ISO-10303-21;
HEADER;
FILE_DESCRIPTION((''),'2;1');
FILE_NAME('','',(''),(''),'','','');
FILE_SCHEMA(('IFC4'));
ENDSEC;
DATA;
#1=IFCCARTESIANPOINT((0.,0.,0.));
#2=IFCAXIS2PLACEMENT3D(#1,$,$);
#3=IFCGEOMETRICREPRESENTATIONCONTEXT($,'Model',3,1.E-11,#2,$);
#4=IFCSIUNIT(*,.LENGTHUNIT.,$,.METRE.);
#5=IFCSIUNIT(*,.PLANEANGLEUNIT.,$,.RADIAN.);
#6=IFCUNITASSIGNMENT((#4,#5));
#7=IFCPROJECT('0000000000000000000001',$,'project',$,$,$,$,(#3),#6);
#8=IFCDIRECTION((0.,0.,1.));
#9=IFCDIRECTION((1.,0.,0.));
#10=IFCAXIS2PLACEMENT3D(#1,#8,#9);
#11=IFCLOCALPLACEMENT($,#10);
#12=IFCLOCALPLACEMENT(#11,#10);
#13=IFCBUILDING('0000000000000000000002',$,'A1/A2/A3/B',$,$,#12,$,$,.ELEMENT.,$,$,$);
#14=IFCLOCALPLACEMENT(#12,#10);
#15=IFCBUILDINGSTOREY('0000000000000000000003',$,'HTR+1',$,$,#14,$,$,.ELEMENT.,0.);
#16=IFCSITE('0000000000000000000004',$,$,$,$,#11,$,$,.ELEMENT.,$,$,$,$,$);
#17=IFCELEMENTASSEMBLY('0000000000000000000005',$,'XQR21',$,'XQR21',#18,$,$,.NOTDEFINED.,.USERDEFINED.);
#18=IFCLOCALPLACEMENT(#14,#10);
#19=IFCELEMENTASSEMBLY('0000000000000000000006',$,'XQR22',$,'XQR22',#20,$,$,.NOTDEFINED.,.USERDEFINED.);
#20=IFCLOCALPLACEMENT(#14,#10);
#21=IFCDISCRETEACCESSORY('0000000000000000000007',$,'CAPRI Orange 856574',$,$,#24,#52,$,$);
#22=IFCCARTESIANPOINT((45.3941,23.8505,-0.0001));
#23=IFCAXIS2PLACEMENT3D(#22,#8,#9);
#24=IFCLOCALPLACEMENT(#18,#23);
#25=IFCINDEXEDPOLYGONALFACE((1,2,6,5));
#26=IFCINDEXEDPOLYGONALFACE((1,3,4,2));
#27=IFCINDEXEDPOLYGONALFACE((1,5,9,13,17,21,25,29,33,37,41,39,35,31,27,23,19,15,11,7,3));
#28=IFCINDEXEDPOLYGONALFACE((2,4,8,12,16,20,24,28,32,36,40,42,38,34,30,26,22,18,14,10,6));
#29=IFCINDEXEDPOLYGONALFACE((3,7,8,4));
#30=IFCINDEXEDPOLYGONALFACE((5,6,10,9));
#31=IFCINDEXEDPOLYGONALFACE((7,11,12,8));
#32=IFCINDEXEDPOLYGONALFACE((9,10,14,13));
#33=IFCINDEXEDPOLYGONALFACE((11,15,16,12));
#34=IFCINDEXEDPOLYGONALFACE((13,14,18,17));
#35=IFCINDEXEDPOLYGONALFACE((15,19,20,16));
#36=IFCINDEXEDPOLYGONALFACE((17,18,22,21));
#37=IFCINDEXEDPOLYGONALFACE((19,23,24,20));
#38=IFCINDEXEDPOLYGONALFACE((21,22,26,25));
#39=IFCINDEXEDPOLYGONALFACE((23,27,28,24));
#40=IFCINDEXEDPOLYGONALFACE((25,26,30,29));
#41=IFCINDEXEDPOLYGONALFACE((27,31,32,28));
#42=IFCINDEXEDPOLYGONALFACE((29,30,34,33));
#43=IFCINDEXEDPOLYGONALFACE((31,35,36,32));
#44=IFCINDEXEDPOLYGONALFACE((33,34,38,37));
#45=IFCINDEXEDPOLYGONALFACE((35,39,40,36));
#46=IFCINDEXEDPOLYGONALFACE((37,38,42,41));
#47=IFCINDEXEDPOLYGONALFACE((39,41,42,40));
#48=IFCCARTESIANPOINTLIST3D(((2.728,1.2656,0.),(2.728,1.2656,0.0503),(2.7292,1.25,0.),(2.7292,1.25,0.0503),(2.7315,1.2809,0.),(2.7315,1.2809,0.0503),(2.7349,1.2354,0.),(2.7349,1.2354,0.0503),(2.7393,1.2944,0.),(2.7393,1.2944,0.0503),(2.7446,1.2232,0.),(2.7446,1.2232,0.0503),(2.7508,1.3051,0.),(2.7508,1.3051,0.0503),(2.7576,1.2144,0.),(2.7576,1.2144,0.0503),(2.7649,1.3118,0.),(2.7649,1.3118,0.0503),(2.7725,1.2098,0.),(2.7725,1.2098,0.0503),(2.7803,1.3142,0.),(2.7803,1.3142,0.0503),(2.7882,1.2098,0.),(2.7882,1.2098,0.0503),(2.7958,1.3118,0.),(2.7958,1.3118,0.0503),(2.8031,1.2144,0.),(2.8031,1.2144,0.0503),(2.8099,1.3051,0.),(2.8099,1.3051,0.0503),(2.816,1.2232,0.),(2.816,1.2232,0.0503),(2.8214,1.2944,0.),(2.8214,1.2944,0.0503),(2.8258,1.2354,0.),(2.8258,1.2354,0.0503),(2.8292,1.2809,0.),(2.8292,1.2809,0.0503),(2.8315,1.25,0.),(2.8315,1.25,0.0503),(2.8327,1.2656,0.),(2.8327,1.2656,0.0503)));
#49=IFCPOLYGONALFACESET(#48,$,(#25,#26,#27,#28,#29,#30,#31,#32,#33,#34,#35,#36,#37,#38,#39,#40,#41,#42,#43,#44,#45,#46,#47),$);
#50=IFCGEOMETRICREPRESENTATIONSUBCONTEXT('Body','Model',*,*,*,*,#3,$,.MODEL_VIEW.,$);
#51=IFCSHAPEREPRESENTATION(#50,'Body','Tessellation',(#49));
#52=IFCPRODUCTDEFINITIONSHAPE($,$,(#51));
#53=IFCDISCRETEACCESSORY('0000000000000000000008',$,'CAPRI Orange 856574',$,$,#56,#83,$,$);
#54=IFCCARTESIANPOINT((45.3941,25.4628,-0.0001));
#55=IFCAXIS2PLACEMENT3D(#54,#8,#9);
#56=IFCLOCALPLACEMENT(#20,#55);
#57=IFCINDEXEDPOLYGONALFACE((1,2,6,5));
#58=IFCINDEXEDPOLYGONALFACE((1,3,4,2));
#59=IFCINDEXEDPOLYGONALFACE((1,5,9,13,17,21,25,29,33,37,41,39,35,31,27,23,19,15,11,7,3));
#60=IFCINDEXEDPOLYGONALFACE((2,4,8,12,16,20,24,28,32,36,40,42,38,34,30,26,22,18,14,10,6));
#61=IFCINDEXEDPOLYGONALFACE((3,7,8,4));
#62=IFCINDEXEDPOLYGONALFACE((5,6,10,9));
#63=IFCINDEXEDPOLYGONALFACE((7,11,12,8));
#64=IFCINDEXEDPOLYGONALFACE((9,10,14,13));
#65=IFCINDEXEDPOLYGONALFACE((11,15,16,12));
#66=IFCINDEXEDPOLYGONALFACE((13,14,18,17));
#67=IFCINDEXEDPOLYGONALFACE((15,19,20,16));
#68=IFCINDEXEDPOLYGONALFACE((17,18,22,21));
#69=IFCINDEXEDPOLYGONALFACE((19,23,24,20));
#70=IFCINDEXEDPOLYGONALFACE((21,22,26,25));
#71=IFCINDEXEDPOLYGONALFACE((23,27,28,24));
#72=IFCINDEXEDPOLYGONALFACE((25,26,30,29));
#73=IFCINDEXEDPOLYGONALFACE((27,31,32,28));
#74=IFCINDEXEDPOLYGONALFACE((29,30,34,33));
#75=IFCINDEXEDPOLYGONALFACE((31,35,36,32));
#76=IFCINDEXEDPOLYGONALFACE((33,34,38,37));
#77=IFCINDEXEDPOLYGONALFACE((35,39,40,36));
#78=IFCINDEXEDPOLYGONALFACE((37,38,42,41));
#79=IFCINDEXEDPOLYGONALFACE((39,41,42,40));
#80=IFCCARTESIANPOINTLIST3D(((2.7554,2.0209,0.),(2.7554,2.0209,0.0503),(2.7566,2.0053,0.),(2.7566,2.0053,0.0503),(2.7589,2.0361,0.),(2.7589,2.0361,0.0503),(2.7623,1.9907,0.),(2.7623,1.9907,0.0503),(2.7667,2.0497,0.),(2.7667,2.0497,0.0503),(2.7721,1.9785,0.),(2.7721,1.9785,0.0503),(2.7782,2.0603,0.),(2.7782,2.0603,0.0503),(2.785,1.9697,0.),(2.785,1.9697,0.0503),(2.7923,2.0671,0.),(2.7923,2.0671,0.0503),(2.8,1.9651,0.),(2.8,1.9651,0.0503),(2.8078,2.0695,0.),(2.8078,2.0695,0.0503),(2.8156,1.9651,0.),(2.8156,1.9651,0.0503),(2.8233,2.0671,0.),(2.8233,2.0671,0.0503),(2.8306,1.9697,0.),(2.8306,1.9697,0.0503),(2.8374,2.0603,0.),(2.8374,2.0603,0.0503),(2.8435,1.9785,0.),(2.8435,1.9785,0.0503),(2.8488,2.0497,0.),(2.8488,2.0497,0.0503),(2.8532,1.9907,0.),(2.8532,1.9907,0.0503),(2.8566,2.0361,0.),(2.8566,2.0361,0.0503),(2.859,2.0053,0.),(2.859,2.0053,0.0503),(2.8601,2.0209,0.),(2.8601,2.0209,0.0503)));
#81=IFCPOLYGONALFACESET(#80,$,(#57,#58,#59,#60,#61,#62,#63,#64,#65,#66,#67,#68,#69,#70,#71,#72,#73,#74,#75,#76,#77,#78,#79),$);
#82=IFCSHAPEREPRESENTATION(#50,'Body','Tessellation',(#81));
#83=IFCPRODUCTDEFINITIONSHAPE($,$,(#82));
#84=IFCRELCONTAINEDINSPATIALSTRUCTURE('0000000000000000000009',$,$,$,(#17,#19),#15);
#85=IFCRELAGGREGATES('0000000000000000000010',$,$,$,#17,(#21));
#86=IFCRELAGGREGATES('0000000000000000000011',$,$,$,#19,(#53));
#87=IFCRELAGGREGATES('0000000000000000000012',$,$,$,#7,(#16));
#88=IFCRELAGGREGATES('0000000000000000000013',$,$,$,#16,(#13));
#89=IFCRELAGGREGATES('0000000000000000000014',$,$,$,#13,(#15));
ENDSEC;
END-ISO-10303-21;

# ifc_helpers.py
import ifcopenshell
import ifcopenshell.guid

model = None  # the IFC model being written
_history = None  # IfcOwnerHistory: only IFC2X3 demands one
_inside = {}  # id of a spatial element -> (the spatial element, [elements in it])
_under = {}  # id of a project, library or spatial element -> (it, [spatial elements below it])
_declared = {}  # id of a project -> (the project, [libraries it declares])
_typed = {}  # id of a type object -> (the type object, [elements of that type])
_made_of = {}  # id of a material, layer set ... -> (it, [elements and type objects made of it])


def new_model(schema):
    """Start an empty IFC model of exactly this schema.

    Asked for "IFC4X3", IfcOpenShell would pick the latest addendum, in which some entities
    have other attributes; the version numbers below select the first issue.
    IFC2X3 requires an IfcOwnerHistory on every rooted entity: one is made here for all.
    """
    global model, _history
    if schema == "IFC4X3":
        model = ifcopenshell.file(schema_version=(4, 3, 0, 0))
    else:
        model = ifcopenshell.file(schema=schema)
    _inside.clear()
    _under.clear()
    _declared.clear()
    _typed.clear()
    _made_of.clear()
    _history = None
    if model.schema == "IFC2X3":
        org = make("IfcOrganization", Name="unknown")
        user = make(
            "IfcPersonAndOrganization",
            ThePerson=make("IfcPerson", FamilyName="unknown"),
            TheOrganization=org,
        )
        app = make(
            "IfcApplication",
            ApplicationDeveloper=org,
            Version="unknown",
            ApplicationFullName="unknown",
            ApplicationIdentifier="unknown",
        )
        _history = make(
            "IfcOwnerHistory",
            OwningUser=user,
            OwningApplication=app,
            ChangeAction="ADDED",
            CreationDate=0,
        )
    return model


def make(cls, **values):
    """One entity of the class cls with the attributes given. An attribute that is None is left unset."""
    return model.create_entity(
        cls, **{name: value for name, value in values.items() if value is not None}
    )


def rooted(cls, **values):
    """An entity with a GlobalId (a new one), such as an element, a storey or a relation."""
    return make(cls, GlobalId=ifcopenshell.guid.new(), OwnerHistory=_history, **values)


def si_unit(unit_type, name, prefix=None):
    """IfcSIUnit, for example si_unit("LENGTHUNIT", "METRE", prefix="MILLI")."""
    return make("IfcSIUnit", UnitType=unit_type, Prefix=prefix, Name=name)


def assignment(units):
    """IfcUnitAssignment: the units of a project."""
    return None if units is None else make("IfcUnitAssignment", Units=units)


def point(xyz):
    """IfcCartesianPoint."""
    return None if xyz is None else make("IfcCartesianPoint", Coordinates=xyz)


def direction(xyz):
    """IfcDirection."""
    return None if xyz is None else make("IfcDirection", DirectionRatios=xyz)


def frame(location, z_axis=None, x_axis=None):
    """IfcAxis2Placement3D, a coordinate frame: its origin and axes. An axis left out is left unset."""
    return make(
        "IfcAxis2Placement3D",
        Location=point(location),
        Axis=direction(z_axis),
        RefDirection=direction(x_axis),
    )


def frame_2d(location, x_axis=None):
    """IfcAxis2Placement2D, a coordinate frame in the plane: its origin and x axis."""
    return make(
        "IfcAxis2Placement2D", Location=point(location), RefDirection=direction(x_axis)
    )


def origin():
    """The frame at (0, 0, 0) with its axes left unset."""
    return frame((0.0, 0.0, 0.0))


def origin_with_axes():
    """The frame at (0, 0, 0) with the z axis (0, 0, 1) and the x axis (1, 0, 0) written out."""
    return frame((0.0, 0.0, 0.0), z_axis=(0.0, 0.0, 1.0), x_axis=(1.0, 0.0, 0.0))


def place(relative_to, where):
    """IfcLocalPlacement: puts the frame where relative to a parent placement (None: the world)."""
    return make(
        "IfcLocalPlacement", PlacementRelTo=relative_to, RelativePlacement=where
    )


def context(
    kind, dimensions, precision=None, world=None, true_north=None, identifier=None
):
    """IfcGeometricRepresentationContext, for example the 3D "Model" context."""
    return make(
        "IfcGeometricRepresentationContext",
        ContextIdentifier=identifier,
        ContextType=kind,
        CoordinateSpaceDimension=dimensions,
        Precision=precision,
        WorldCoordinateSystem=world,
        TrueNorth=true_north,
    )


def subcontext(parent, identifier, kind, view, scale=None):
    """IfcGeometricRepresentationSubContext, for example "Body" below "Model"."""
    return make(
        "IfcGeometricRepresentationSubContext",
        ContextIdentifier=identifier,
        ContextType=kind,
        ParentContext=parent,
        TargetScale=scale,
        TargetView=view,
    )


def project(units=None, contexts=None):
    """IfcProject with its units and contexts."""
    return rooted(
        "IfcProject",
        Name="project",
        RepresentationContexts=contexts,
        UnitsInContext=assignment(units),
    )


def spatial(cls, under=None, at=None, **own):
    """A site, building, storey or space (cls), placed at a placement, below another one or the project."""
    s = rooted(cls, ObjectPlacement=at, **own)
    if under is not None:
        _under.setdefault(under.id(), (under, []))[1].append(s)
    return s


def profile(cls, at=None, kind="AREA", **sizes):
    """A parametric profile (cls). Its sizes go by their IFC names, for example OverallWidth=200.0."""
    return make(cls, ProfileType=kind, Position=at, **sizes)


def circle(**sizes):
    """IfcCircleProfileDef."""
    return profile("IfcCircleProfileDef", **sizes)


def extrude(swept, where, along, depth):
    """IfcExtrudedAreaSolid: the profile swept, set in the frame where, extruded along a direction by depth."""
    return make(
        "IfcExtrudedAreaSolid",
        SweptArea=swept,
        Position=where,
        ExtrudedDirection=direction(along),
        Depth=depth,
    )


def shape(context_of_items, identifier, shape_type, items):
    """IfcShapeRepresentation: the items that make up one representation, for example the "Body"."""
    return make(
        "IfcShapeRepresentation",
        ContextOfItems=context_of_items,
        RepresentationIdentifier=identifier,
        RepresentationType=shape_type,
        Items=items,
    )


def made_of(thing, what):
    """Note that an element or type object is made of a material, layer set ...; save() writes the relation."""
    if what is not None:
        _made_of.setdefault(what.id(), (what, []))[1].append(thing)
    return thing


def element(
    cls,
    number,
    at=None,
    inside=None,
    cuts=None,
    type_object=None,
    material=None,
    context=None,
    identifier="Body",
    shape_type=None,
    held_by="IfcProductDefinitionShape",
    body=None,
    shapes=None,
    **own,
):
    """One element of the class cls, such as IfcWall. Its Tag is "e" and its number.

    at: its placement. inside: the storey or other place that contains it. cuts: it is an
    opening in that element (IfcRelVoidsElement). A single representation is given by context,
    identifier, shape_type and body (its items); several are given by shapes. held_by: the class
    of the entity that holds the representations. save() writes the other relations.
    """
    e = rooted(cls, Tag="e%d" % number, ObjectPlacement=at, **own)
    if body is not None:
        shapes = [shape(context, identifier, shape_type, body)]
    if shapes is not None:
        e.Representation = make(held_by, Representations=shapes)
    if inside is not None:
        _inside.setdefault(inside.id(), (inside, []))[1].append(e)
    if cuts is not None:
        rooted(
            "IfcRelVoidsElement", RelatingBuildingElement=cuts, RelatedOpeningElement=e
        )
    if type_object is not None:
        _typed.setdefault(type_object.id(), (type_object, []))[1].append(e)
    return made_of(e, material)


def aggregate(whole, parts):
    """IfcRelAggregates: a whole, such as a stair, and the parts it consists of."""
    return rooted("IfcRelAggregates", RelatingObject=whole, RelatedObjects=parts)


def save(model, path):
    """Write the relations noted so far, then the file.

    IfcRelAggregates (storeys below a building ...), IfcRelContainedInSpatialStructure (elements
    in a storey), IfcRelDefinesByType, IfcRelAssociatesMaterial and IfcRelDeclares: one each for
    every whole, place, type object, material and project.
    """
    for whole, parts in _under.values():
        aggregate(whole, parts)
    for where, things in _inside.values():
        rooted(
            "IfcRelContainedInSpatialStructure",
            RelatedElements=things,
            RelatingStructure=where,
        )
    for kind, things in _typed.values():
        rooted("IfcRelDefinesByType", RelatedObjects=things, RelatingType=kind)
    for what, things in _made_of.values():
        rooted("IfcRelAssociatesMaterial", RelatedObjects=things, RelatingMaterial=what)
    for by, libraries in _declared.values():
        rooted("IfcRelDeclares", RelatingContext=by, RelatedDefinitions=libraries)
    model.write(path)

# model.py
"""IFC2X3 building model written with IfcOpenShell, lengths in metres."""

from ifc_helpers import new_model, si_unit, frame, frame_2d, origin, origin_with_axes, place, context, subcontext, project, spatial, circle, extrude, element, aggregate, save


model = new_model("IFC2X3")

# Units and contexts
model_context = context("Model", 3, precision=1e-11, world=origin())
body_context = subcontext(model_context, "Body", "Model", "MODEL_VIEW")
ifc_project = project(units=[si_unit("LENGTHUNIT", "METRE"), si_unit("PLANEANGLEUNIT", "RADIAN")], contexts=[model_context])

# Site, building, storey
site_placement = place(None, origin_with_axes())
site = spatial("IfcSite", under=ifc_project, at=site_placement, CompositionType="ELEMENT")
building_placement = place(site_placement, origin_with_axes())
building = spatial("IfcBuilding", under=site, at=building_placement, Name="A1/A2/A3/B", CompositionType="ELEMENT")
storey_placement = place(building_placement, origin_with_axes())
storey = spatial("IfcBuildingStorey", under=building, at=storey_placement, Name="HTR+1", CompositionType="ELEMENT", Elevation=0.0)

# Element assembly
assembly_1_placement = place(storey_placement, origin_with_axes())
assembly_1 = element("IfcElementAssembly", 1, at=assembly_1_placement, inside=storey, Name="XQR21", ObjectType="XQR21", AssemblyPlace="NOTDEFINED", PredefinedType="USERDEFINED")

# Element assembly
assembly_2_placement = place(storey_placement, origin_with_axes())
assembly_2 = element("IfcElementAssembly", 2, at=assembly_2_placement, inside=storey, Name="XQR22", ObjectType="XQR22", AssemblyPlace="NOTDEFINED", PredefinedType="USERDEFINED")

# Discrete accessories
discrete_accessory_1_placement = place(assembly_1_placement, frame((45.3941, 23.8505, -0.0001), z_axis=(0.0, 0.0, 1.0), x_axis=(1.0, 0.0, 0.0)))
discrete_accessory_1 = element("IfcDiscreteAccessory", 3, at=discrete_accessory_1_placement, Name="CAPRI Orange 856574", context=body_context, shape_type="SweptSolid", body=[
    extrude(circle(Radius=0.0525, at=frame_2d((1.2617, -2.7803), x_axis=(1.0, 0.0))), frame((0.0, 0.0, 0.0), z_axis=(0.0, 0.0, 1.0), x_axis=(0.0, 1.0, 0.0)), (0.0, 0.0, 1.0), 0.0503),
])
aggregate(assembly_1, [discrete_accessory_1])
discrete_accessory_2_placement = place(assembly_2_placement, frame((45.3941, 25.4628, -0.0001), z_axis=(0.0, 0.0, 1.0), x_axis=(1.0, 0.0, 0.0)))
discrete_accessory_2 = element("IfcDiscreteAccessory", 4, at=discrete_accessory_2_placement, Name="CAPRI Orange 856574", context=body_context, shape_type="SweptSolid", body=[
    extrude(circle(Radius=0.0525, at=frame_2d((2.017, -2.8078), x_axis=(1.0, 0.0))), frame((0.0, 0.0, 0.0), z_axis=(0.0, 0.0, 1.0), x_axis=(0.0, 1.0, 0.0)), (0.0, 0.0, 1.0), 0.0503),
])
aggregate(assembly_2, [discrete_accessory_2])

save(model, "model.ifc")
